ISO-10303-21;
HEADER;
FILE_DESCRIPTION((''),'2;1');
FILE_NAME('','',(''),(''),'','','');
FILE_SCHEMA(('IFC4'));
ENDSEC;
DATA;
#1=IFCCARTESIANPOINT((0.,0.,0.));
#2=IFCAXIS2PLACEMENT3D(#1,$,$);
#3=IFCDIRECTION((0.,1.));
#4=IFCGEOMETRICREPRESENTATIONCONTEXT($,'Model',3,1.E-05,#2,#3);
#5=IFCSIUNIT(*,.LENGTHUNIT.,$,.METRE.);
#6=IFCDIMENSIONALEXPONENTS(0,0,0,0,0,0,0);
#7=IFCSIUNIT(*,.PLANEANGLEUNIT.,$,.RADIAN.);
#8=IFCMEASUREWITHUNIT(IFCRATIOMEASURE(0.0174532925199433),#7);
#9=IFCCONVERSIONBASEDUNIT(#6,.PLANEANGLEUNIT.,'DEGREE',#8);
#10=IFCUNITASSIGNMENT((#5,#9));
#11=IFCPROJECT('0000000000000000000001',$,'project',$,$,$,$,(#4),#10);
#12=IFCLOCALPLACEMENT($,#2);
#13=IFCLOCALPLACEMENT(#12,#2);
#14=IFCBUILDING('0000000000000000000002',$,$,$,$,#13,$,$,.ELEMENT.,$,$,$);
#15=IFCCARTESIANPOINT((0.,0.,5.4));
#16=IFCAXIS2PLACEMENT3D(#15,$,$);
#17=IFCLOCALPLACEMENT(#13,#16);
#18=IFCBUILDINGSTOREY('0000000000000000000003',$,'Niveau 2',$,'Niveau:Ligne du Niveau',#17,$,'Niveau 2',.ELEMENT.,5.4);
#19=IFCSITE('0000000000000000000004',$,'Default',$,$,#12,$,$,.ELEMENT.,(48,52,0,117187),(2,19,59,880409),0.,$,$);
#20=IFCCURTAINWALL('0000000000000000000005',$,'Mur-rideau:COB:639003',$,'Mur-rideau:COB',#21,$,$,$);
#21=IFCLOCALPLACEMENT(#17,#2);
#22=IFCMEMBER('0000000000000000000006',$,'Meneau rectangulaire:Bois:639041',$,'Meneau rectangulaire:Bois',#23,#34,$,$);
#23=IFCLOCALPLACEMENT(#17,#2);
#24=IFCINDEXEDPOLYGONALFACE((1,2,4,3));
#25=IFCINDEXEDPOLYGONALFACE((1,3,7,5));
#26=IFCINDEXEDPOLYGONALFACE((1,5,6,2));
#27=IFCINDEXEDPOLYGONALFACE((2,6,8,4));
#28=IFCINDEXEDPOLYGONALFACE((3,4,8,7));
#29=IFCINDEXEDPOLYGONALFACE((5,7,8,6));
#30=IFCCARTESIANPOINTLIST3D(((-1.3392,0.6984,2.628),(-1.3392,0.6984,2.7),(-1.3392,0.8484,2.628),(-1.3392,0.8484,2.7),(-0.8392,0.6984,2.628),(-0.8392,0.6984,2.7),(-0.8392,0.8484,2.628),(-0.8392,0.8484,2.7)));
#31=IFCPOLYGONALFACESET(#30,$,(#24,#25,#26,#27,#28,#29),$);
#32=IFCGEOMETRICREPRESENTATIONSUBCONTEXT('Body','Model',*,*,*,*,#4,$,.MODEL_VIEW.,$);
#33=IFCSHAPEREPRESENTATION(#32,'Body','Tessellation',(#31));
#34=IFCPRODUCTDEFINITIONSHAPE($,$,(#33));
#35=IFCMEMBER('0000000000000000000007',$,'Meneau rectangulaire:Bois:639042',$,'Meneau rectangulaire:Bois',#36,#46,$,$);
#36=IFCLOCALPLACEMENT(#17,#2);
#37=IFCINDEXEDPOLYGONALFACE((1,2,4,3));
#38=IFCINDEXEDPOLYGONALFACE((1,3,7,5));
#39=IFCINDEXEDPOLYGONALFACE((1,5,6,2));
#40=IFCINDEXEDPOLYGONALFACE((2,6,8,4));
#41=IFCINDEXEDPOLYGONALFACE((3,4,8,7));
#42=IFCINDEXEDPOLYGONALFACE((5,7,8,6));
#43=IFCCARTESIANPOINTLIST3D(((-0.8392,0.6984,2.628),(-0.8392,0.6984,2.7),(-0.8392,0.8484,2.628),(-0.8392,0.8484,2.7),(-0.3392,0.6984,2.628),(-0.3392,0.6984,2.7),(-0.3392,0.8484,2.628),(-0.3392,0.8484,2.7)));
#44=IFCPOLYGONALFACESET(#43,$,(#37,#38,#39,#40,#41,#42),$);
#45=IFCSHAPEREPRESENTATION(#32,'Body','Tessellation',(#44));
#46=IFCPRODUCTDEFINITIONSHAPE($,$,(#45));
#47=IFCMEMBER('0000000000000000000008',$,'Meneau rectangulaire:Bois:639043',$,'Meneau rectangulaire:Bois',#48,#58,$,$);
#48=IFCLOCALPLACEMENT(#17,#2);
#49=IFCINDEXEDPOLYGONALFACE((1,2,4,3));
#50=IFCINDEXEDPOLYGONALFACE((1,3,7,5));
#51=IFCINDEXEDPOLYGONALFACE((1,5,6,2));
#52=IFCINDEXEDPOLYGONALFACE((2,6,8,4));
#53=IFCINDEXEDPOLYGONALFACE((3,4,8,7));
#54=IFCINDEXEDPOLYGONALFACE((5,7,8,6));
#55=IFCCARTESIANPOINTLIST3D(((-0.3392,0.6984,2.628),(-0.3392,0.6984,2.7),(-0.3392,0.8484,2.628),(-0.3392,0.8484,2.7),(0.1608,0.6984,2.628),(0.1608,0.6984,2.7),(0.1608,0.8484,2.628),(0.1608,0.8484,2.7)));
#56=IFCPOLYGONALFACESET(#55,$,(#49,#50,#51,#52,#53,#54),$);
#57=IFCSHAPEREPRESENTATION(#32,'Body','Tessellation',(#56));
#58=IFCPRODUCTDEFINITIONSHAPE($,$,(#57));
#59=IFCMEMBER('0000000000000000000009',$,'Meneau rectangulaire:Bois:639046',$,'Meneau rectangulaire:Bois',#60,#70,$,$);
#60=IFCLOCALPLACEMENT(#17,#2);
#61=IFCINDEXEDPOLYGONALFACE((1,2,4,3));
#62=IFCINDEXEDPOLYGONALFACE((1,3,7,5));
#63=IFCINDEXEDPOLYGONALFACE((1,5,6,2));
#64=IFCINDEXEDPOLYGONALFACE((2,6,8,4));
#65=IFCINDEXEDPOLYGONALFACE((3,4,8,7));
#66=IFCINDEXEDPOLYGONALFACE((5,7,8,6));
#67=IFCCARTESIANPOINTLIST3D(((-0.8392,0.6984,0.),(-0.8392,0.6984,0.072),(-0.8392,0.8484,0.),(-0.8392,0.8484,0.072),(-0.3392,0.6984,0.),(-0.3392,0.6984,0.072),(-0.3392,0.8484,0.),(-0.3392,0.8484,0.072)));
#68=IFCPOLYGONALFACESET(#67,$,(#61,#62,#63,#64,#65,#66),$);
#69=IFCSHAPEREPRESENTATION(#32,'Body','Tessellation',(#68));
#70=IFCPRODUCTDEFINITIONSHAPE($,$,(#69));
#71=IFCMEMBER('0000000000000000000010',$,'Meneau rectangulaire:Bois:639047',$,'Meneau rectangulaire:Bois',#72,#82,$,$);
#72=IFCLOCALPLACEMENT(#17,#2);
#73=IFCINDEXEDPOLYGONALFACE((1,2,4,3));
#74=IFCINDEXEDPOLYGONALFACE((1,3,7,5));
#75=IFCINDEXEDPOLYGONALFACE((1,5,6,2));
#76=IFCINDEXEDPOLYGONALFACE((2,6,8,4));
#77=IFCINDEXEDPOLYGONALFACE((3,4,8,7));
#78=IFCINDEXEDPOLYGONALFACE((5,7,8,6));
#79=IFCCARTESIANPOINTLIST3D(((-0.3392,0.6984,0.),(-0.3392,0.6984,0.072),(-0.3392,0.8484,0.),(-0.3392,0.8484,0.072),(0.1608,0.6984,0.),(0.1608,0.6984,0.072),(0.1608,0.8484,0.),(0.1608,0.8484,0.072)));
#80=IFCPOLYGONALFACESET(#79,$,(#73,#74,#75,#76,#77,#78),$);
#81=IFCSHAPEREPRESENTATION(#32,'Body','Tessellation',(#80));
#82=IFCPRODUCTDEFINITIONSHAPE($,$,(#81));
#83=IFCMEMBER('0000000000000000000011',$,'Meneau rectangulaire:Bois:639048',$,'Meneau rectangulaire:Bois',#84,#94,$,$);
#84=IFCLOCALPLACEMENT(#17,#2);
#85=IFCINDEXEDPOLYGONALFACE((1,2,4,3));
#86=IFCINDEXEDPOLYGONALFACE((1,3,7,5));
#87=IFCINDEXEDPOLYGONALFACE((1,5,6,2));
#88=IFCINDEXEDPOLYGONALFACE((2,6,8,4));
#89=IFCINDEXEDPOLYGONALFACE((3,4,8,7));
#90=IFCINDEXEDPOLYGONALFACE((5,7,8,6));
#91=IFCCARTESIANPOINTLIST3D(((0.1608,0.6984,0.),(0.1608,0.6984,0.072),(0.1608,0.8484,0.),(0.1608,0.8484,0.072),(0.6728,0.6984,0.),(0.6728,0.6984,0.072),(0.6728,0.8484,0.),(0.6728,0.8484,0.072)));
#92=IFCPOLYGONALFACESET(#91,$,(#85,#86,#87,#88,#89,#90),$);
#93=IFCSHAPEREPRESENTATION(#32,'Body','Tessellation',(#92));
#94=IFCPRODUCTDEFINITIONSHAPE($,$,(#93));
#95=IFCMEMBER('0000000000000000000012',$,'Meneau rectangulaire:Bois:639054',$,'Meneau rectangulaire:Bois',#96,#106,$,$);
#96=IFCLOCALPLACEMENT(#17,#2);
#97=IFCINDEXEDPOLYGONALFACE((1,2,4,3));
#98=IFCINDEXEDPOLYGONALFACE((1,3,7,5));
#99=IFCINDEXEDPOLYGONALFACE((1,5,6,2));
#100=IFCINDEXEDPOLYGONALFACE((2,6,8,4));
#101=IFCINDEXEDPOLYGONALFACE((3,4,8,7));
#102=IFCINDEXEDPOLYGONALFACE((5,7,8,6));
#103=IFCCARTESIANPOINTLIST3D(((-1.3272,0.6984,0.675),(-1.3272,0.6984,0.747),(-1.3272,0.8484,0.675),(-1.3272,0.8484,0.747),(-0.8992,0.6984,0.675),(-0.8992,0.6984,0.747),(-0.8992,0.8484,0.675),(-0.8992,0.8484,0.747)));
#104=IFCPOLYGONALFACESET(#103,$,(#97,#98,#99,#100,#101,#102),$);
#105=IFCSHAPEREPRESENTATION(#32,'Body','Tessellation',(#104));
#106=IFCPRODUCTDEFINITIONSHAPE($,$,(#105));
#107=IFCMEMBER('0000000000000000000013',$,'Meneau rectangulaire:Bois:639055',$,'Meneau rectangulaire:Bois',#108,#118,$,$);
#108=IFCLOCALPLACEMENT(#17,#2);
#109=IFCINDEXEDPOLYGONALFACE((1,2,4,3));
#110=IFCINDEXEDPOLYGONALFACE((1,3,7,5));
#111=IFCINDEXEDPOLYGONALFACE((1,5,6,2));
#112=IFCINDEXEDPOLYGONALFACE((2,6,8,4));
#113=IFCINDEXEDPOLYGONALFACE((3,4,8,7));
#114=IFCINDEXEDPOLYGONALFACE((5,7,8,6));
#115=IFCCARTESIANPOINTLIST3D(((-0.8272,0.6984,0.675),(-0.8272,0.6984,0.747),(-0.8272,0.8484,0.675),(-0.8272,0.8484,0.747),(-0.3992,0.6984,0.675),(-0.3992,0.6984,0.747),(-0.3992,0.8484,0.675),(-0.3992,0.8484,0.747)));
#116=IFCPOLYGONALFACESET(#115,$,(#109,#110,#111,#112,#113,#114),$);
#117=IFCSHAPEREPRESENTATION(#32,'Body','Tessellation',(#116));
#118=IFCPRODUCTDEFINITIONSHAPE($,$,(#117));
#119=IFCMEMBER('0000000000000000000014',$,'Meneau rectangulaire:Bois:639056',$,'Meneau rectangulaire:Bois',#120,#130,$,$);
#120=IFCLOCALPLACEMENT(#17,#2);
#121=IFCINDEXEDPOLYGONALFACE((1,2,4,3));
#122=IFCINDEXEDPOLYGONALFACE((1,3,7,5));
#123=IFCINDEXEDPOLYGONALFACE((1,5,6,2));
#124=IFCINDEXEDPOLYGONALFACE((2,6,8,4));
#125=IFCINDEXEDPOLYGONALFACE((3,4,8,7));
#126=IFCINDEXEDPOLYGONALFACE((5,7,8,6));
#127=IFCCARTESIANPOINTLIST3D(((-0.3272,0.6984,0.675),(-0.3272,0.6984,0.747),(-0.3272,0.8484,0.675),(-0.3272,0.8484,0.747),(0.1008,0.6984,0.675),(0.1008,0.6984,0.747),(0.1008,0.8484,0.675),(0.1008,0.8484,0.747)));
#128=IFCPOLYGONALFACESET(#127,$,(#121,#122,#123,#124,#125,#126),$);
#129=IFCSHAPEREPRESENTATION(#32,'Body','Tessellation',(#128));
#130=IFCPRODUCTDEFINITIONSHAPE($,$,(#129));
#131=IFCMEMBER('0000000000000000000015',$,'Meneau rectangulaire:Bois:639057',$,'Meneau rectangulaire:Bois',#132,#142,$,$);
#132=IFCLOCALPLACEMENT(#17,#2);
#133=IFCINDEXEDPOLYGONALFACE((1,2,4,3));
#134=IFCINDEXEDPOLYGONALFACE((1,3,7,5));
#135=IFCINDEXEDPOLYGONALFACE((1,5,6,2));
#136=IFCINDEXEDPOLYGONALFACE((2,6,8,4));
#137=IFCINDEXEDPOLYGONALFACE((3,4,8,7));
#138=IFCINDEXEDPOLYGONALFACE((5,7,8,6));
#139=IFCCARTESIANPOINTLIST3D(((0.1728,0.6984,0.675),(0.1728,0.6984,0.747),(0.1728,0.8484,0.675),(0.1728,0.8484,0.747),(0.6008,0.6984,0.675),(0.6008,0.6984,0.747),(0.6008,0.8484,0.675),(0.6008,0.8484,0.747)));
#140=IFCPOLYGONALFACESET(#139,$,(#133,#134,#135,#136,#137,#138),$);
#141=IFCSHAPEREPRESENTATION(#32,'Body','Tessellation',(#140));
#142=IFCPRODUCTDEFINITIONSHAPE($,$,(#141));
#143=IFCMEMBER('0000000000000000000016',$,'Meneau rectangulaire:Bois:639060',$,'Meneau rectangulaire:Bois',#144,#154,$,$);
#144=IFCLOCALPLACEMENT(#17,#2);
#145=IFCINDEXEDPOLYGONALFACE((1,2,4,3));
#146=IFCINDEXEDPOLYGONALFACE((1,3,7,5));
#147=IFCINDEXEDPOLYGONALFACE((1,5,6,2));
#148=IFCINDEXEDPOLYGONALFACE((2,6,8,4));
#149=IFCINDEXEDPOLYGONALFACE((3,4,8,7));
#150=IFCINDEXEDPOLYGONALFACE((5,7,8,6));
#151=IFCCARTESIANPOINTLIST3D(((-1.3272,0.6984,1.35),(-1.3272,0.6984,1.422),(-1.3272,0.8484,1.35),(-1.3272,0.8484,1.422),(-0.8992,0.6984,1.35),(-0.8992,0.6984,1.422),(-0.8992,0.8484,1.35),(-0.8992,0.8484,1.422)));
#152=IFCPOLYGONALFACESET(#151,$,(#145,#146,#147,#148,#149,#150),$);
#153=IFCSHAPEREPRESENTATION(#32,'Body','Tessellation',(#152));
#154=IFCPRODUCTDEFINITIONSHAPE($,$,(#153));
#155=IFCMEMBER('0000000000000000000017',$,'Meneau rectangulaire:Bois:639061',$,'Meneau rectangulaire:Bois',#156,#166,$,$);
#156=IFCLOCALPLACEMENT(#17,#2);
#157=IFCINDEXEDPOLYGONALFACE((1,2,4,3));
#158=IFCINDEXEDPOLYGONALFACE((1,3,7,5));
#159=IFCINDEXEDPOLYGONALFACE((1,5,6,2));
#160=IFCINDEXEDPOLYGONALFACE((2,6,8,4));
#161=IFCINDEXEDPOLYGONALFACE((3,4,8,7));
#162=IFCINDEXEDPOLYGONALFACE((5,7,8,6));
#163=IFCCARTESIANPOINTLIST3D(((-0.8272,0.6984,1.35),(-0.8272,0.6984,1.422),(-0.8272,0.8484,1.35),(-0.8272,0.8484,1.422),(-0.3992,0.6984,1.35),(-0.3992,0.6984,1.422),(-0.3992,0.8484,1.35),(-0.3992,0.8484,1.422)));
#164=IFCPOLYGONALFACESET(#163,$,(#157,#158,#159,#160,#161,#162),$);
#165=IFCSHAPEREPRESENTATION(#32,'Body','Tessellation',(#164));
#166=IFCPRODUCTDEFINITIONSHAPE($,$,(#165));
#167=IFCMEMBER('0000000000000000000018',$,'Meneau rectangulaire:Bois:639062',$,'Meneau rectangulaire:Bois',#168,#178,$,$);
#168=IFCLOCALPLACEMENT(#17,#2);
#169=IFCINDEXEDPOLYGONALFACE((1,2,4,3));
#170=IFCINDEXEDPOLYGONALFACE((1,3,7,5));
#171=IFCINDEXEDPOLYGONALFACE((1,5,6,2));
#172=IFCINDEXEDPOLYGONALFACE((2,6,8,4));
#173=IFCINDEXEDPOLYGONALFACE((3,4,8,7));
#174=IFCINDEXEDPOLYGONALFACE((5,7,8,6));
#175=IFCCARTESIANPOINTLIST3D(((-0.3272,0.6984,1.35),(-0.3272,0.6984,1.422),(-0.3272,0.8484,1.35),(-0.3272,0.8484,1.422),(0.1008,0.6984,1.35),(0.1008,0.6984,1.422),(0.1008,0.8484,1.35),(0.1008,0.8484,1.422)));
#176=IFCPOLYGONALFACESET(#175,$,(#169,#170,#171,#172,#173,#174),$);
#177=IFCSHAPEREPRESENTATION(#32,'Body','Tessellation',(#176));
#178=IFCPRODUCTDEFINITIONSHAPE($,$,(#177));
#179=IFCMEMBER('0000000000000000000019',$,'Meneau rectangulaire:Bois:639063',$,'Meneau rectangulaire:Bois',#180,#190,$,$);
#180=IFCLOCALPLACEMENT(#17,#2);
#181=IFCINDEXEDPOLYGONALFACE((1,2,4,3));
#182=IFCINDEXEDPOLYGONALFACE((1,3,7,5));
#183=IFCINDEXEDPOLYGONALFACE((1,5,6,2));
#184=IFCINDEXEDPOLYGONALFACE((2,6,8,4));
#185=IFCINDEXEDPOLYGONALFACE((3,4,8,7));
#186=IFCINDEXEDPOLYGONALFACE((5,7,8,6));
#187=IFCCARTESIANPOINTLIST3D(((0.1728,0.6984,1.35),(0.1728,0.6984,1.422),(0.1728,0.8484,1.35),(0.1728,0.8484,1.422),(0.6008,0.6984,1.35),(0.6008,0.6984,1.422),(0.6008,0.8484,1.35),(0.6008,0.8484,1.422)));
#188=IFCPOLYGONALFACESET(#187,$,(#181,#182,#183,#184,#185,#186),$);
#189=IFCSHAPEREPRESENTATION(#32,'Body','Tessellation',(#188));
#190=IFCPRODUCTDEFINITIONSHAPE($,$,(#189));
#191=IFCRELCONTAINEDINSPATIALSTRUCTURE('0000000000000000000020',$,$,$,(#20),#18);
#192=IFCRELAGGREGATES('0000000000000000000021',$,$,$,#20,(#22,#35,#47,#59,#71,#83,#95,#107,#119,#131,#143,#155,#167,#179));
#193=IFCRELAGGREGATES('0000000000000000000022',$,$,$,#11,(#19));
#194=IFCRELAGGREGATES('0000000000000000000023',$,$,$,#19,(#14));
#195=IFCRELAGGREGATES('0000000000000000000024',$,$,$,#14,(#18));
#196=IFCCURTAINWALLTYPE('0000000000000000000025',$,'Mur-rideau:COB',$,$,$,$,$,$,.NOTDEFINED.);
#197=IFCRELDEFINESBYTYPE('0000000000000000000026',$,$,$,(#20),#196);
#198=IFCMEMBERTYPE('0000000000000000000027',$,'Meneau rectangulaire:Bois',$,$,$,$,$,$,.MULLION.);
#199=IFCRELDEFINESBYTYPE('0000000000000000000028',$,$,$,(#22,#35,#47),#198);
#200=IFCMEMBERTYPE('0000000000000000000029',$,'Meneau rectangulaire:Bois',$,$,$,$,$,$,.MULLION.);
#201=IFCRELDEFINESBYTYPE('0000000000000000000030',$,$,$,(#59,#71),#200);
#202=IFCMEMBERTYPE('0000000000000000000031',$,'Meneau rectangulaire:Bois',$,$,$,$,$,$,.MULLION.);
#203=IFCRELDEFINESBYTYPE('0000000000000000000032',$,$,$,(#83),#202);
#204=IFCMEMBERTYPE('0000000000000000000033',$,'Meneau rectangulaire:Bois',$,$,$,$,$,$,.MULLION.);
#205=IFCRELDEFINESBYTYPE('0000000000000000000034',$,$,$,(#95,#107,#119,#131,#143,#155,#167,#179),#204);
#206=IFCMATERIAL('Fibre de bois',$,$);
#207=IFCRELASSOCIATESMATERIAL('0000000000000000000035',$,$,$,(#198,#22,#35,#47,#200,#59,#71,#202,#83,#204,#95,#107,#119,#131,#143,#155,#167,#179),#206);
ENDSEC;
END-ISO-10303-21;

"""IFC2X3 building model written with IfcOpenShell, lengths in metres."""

from ifc_helpers import new_model, entity, si_unit, converted_unit, direction, frame, origin, origin_2d_with_axis, place, context, subcontext, project, spatial, rectangle, extrude, source, transform, mapped, material, type_object, type_shapes, element, aggregate, save


model = new_model("IFC2X3")

# Units and contexts
model_context = context("Model", 3, precision=1e-05, world=origin(), true_north=direction((0.0, 1.0)))
body_context = subcontext(model_context, "Body", "Model", "MODEL_VIEW")
ifc_project = project(units=[si_unit("LENGTHUNIT", "METRE"), converted_unit("PLANEANGLEUNIT", "DEGREE", entity("IfcRatioMeasure", 0.0174532925199433), si_unit("PLANEANGLEUNIT", "RADIAN"), dimensions=[0, 0, 0, 0, 0, 0, 0])], contexts=[model_context])

# Site, building, storey
site_placement = place(None, origin())
site = spatial("IfcSite", under=ifc_project, at=site_placement, Name="Default", CompositionType="ELEMENT", RefLatitude=(48, 52, 0, 117187), RefLongitude=(2, 19, 59, 880409), RefElevation=0.0)
building_placement = place(site_placement, origin())
building = spatial("IfcBuilding", under=site, at=building_placement, CompositionType="ELEMENT")
storey_placement = place(building_placement, frame((0.0, 0.0, 5.4)))
storey = spatial("IfcBuildingStorey", under=building, at=storey_placement, Name="Niveau 2", ObjectType="Niveau:Ligne du Niveau", LongName="Niveau 2", CompositionType="ELEMENT", Elevation=5.4)

# Curtain wall, members
curtain_wall_type_1 = type_object("IfcCurtainWallType", Name="Mur-rideau:COB", PredefinedType="NOTDEFINED")
curtain_wall_1_placement = place(storey_placement, frame((0.0, 0.0, -5.4)))
curtain_wall_1 = element("IfcCurtainWall", 1, at=curtain_wall_1_placement, inside=storey, type_object=curtain_wall_type_1, Name="Mur-rideau:COB:639003", ObjectType="Mur-rideau:COB")
ifc_material_1 = material(Name="Fibre de bois")
member_type_1 = type_object("IfcMemberType", Name="Meneau rectangulaire:Bois", PredefinedType="MULLION", material=ifc_material_1)
shared_shape_1 = source(origin(), body_context, "Body", "SweptSolid", [
    extrude(rectangle(XDim=0.15, YDim=0.072, at=origin_2d_with_axis()), frame((-0.036, 0.0, -0.5), z_axis=(0.0, 0.0, 1.0), x_axis=(0.0, -1.0, 0.0)), (0.0, 0.0, 1.0), 0.5),
])
type_shapes(member_type_1, [shared_shape_1])
member_1_placement = place(storey_placement, frame((-0.8392, 0.7734, 2.7), z_axis=(1.0, 0.0, 0.0), x_axis=(0.0, 0.0, 1.0)))
member_1 = element("IfcMember", 2, at=member_1_placement, type_object=member_type_1, material=ifc_material_1, Name="Meneau rectangulaire:Bois:639041", ObjectType="Meneau rectangulaire:Bois", context=body_context, shape_type="MappedRepresentation", body=[
    mapped(shared_shape_1, transform((0.0, 0.0, 0.0), scale=1.0)),
])
member_2_placement = place(storey_placement, frame((-0.3392, 0.7734, 2.7), z_axis=(1.0, 0.0, 0.0), x_axis=(0.0, 0.0, 1.0)))
member_2 = element("IfcMember", 3, at=member_2_placement, type_object=member_type_1, material=ifc_material_1, Name="Meneau rectangulaire:Bois:639042", ObjectType="Meneau rectangulaire:Bois", context=body_context, shape_type="MappedRepresentation", body=[
    mapped(shared_shape_1, transform((0.0, 0.0, 0.0), scale=1.0)),
])
member_3_placement = place(storey_placement, frame((0.1608, 0.7734, 2.7), z_axis=(1.0, 0.0, 0.0), x_axis=(0.0, 0.0, 1.0)))
member_3 = element("IfcMember", 4, at=member_3_placement, type_object=member_type_1, material=ifc_material_1, Name="Meneau rectangulaire:Bois:639043", ObjectType="Meneau rectangulaire:Bois", context=body_context, shape_type="MappedRepresentation", body=[
    mapped(shared_shape_1, transform((0.0, 0.0, 0.0), scale=1.0)),
])
member_type_2 = type_object("IfcMemberType", Name="Meneau rectangulaire:Bois", PredefinedType="MULLION", material=ifc_material_1)
shared_shape_2 = source(origin(), body_context, "Body", "SweptSolid", [
    extrude(rectangle(XDim=0.15, YDim=0.072, at=origin_2d_with_axis()), frame((-0.036, 0.0, -0.5), z_axis=(0.0, 0.0, 1.0), x_axis=(0.0, -1.0, 0.0)), (0.0, 0.0, 1.0), 0.5),
])
type_shapes(member_type_2, [shared_shape_2])
member_4_placement = place(storey_placement, frame((-0.8392, 0.7734, 0.0), z_axis=(-1.0, 0.0, 0.0), x_axis=(0.0, 0.0, -1.0)))
member_4 = element("IfcMember", 5, at=member_4_placement, type_object=member_type_2, material=ifc_material_1, Name="Meneau rectangulaire:Bois:639046", ObjectType="Meneau rectangulaire:Bois", context=body_context, shape_type="MappedRepresentation", body=[
    mapped(shared_shape_2, transform((0.0, 0.0, 0.0), scale=1.0)),
])
member_5_placement = place(storey_placement, frame((-0.3392, 0.7734, 0.0), z_axis=(-1.0, 0.0, 0.0), x_axis=(0.0, 0.0, -1.0)))
member_5 = element("IfcMember", 6, at=member_5_placement, type_object=member_type_2, material=ifc_material_1, Name="Meneau rectangulaire:Bois:639047", ObjectType="Meneau rectangulaire:Bois", context=body_context, shape_type="MappedRepresentation", body=[
    mapped(shared_shape_2, transform((0.0, 0.0, 0.0), scale=1.0)),
])
member_type_3 = type_object("IfcMemberType", Name="Meneau rectangulaire:Bois", PredefinedType="MULLION", material=ifc_material_1)
shared_shape_3 = source(origin(), body_context, "Body", "SweptSolid", [
    extrude(rectangle(XDim=0.15, YDim=0.072, at=origin_2d_with_axis()), frame((-0.036, 0.0, -0.512), z_axis=(0.0, 0.0, 1.0), x_axis=(0.0, -1.0, 0.0)), (0.0, 0.0, 1.0), 0.512),
])
type_shapes(member_type_3, [shared_shape_3])
member_6_placement = place(storey_placement, frame((0.1608, 0.7734, 0.0), z_axis=(-1.0, 0.0, 0.0), x_axis=(0.0, 0.0, -1.0)))
member_6 = element("IfcMember", 7, at=member_6_placement, type_object=member_type_3, material=ifc_material_1, Name="Meneau rectangulaire:Bois:639048", ObjectType="Meneau rectangulaire:Bois", context=body_context, shape_type="MappedRepresentation", body=[
    mapped(shared_shape_3, transform((0.0, 0.0, 0.0), scale=1.0)),
])
member_type_4 = type_object("IfcMemberType", Name="Meneau rectangulaire:Bois", PredefinedType="MULLION", material=ifc_material_1)
shared_shape_4 = source(origin(), body_context, "Body", "SweptSolid", [
    extrude(rectangle(XDim=0.15, YDim=0.072, at=origin_2d_with_axis()), frame((-0.024, 0.0, -0.428), z_axis=(0.0, 0.0, 1.0), x_axis=(0.0, -1.0, 0.0)), (0.0, 0.0, 1.0), 0.428),
])
type_shapes(member_type_4, [shared_shape_4])
member_7_placement = place(storey_placement, frame((-0.8992, 0.7734, 0.735), z_axis=(1.0, 0.0, 0.0), x_axis=(0.0, 0.0, 1.0)))
member_7 = element("IfcMember", 8, at=member_7_placement, type_object=member_type_4, material=ifc_material_1, Name="Meneau rectangulaire:Bois:639054", ObjectType="Meneau rectangulaire:Bois", context=body_context, shape_type="MappedRepresentation", body=[
    mapped(shared_shape_4, transform((0.0, 0.0, 0.0), scale=1.0)),
])
member_8_placement = place(storey_placement, frame((-0.3992, 0.7734, 0.735), z_axis=(1.0, 0.0, 0.0), x_axis=(0.0, 0.0, 1.0)))
member_8 = element("IfcMember", 9, at=member_8_placement, type_object=member_type_4, material=ifc_material_1, Name="Meneau rectangulaire:Bois:639055", ObjectType="Meneau rectangulaire:Bois", context=body_context, shape_type="MappedRepresentation", body=[
    mapped(shared_shape_4, transform((0.0, 0.0, 0.0), scale=1.0)),
])
member_9_placement = place(storey_placement, frame((0.1008, 0.7734, 0.735), z_axis=(1.0, 0.0, 0.0), x_axis=(0.0, 0.0, 1.0)))
member_9 = element("IfcMember", 10, at=member_9_placement, type_object=member_type_4, material=ifc_material_1, Name="Meneau rectangulaire:Bois:639056", ObjectType="Meneau rectangulaire:Bois", context=body_context, shape_type="MappedRepresentation", body=[
    mapped(shared_shape_4, transform((0.0, 0.0, 0.0), scale=1.0)),
])
member_10_placement = place(storey_placement, frame((0.6008, 0.7734, 0.735), z_axis=(1.0, 0.0, 0.0), x_axis=(0.0, 0.0, 1.0)))
member_10 = element("IfcMember", 11, at=member_10_placement, type_object=member_type_4, material=ifc_material_1, Name="Meneau rectangulaire:Bois:639057", ObjectType="Meneau rectangulaire:Bois", context=body_context, shape_type="MappedRepresentation", body=[
    mapped(shared_shape_4, transform((0.0, 0.0, 0.0), scale=1.0)),
])
member_11_placement = place(storey_placement, frame((-0.8992, 0.7734, 1.41), z_axis=(1.0, 0.0, 0.0), x_axis=(0.0, 0.0, 1.0)))
member_11 = element("IfcMember", 12, at=member_11_placement, type_object=member_type_4, material=ifc_material_1, Name="Meneau rectangulaire:Bois:639060", ObjectType="Meneau rectangulaire:Bois", context=body_context, shape_type="MappedRepresentation", body=[
    mapped(shared_shape_4, transform((0.0, 0.0, 0.0), scale=1.0)),
])
member_12_placement = place(storey_placement, frame((-0.3992, 0.7734, 1.41), z_axis=(1.0, 0.0, 0.0), x_axis=(0.0, 0.0, 1.0)))
member_12 = element("IfcMember", 13, at=member_12_placement, type_object=member_type_4, material=ifc_material_1, Name="Meneau rectangulaire:Bois:639061", ObjectType="Meneau rectangulaire:Bois", context=body_context, shape_type="MappedRepresentation", body=[
    mapped(shared_shape_4, transform((0.0, 0.0, 0.0), scale=1.0)),
])
member_13_placement = place(storey_placement, frame((0.1008, 0.7734, 1.41), z_axis=(1.0, 0.0, 0.0), x_axis=(0.0, 0.0, 1.0)))
member_13 = element("IfcMember", 14, at=member_13_placement, type_object=member_type_4, material=ifc_material_1, Name="Meneau rectangulaire:Bois:639062", ObjectType="Meneau rectangulaire:Bois", context=body_context, shape_type="MappedRepresentation", body=[
    mapped(shared_shape_4, transform((0.0, 0.0, 0.0), scale=1.0)),
])
member_14_placement = place(storey_placement, frame((0.6008, 0.7734, 1.41), z_axis=(1.0, 0.0, 0.0), x_axis=(0.0, 0.0, 1.0)))
member_14 = element("IfcMember", 15, at=member_14_placement, type_object=member_type_4, material=ifc_material_1, Name="Meneau rectangulaire:Bois:639063", ObjectType="Meneau rectangulaire:Bois", context=body_context, shape_type="MappedRepresentation", body=[
    mapped(shared_shape_4, transform((0.0, 0.0, 0.0), scale=1.0)),
])
aggregate(curtain_wall_1, [member_1, member_2, member_3, member_4, member_5, member_6, member_7, member_8, member_9, member_10, member_11, member_12, member_13, member_14])

save(model, "model.ifc")
